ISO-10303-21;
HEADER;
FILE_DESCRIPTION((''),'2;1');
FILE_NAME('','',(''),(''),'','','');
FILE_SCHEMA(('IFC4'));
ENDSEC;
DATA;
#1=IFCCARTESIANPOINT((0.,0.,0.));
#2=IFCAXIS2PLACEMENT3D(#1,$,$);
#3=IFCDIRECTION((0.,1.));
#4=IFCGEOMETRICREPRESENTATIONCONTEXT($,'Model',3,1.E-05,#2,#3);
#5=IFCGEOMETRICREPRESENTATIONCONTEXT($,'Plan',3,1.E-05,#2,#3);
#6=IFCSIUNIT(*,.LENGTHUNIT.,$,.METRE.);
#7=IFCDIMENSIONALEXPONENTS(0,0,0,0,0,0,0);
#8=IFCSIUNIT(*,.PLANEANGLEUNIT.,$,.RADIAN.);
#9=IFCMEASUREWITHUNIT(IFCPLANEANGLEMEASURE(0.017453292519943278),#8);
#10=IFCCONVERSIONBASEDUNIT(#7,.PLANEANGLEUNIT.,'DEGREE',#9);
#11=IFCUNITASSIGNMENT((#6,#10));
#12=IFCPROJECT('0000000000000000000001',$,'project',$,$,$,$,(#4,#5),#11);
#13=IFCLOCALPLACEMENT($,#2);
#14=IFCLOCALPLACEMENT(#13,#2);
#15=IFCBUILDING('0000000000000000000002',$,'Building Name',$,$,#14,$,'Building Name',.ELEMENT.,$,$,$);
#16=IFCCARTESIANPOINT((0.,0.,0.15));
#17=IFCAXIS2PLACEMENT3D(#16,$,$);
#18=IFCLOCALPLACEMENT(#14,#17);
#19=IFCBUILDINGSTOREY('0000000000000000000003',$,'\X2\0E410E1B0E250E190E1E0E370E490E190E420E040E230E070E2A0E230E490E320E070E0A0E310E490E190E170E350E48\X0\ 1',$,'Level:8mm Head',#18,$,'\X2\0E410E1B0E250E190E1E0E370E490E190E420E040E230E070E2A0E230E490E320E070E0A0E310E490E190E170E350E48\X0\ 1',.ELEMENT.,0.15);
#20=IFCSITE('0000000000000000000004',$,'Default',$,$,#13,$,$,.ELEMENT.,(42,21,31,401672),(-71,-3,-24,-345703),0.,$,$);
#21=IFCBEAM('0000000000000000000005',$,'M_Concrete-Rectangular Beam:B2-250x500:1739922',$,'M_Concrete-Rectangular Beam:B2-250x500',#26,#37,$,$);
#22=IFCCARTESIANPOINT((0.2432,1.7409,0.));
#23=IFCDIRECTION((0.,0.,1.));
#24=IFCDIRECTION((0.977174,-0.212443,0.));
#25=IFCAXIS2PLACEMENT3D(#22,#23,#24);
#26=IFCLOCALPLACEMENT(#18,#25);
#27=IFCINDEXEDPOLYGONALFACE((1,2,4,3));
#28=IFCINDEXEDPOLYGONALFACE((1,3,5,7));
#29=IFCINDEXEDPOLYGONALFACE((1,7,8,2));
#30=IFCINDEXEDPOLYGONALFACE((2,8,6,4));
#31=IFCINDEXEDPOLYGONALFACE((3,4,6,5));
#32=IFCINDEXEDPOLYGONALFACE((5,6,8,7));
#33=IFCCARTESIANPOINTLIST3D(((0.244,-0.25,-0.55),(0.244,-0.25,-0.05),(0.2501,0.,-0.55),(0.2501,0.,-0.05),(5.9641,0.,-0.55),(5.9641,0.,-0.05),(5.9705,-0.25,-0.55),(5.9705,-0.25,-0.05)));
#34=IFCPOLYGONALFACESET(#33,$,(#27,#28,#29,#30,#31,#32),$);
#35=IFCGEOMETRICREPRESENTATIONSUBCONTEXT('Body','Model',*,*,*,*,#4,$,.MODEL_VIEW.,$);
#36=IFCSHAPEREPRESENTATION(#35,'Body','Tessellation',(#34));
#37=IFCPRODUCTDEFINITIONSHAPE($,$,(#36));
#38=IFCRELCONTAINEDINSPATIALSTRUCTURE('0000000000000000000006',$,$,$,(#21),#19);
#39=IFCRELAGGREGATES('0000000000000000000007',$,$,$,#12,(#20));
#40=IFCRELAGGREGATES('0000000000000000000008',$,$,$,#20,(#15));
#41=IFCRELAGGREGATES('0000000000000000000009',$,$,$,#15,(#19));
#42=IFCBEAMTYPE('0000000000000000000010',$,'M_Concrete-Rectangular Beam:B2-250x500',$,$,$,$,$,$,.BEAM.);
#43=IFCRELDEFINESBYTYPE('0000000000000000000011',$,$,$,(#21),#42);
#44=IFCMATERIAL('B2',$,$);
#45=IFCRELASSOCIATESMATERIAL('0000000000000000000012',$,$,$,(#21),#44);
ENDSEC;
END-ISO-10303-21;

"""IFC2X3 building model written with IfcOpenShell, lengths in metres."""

from ifc_helpers import new_model, entity, si_unit, converted_unit, direction, frame, frame_2d, origin, place, context, subcontext, project, spatial, rectangle, extrude, clip, halfspace, material, type_object, element, save


model = new_model("IFC2X3")

# Units and contexts
model_context = context("Model", 3, precision=1e-05, world=origin(), true_north=direction((0.0, 1.0)))
plan_context = context("Plan", 3, precision=1e-05, world=origin(), true_north=direction((0.0, 1.0)))
body_context = subcontext(model_context, "Body", "Model", "MODEL_VIEW")
ifc_project = project(units=[si_unit("LENGTHUNIT", "METRE"), converted_unit("PLANEANGLEUNIT", "DEGREE", entity("IfcPlaneAngleMeasure", 0.017453292519943278), si_unit("PLANEANGLEUNIT", "RADIAN"), dimensions=[0, 0, 0, 0, 0, 0, 0])], contexts=[model_context, plan_context])

# Site, building, storey
site_placement = place(None, origin())
site = spatial("IfcSite", under=ifc_project, at=site_placement, Name="Default", CompositionType="ELEMENT", RefLatitude=(42, 21, 31, 401672), RefLongitude=(-71, -3, -24, -345703), RefElevation=0.0)
building_placement = place(site_placement, origin())
building = spatial("IfcBuilding", under=site, at=building_placement, Name="Building Name", LongName="Building Name", CompositionType="ELEMENT")
storey_placement = place(building_placement, frame((0.0, 0.0, 0.15)))
storey = spatial("IfcBuildingStorey", under=building, at=storey_placement, Name="แปลนพื้นโครงสร้างชั้นที่ 1", ObjectType="Level:8mm Head", LongName="แปลนพื้นโครงสร้างชั้นที่ 1", CompositionType="ELEMENT", Elevation=0.15)

# Beam
ifc_material_1 = material(Name="B2")
beam_type = type_object("IfcBeamType", Name="M_Concrete-Rectangular Beam:B2-250x500", PredefinedType="BEAM")
beam_1_placement = place(storey_placement, frame((0.2432, 1.7409, 0.0), z_axis=(0.0, 0.0, 1.0), x_axis=(0.977174, -0.212443, 0.0)))
element("IfcBeam", 1, at=beam_1_placement, inside=storey, type_object=beam_type, material=ifc_material_1, Name="M_Concrete-Rectangular Beam:B2-250x500:1739922", ObjectType="M_Concrete-Rectangular Beam:B2-250x500", context=body_context, shape_type="Clipping", body=[
    clip(clip(extrude(rectangle(XDim=0.5, YDim=0.25, at=frame_2d((0.0, 0.0), x_axis=(1.0, 0.0))), frame((0.244, -0.125, -0.3), z_axis=(1.0, 0.0, 0.0), x_axis=(0.0, 0.0, -1.0)), (0.0, 0.0, 1.0), 5.7266), halfspace(frame((0.2435, -0.2686, -0.05), z_axis=(-0.999703, 0.024378, 0.0), x_axis=(-0.024378, -0.999703, 0.0)), False)), halfspace(frame((5.9709, -0.2658, -0.65), z_axis=(0.99967, 0.025702, 0.0), x_axis=(0.025702, -0.99967, 0.0)), False)),
])

save(model, "model.ifc")
